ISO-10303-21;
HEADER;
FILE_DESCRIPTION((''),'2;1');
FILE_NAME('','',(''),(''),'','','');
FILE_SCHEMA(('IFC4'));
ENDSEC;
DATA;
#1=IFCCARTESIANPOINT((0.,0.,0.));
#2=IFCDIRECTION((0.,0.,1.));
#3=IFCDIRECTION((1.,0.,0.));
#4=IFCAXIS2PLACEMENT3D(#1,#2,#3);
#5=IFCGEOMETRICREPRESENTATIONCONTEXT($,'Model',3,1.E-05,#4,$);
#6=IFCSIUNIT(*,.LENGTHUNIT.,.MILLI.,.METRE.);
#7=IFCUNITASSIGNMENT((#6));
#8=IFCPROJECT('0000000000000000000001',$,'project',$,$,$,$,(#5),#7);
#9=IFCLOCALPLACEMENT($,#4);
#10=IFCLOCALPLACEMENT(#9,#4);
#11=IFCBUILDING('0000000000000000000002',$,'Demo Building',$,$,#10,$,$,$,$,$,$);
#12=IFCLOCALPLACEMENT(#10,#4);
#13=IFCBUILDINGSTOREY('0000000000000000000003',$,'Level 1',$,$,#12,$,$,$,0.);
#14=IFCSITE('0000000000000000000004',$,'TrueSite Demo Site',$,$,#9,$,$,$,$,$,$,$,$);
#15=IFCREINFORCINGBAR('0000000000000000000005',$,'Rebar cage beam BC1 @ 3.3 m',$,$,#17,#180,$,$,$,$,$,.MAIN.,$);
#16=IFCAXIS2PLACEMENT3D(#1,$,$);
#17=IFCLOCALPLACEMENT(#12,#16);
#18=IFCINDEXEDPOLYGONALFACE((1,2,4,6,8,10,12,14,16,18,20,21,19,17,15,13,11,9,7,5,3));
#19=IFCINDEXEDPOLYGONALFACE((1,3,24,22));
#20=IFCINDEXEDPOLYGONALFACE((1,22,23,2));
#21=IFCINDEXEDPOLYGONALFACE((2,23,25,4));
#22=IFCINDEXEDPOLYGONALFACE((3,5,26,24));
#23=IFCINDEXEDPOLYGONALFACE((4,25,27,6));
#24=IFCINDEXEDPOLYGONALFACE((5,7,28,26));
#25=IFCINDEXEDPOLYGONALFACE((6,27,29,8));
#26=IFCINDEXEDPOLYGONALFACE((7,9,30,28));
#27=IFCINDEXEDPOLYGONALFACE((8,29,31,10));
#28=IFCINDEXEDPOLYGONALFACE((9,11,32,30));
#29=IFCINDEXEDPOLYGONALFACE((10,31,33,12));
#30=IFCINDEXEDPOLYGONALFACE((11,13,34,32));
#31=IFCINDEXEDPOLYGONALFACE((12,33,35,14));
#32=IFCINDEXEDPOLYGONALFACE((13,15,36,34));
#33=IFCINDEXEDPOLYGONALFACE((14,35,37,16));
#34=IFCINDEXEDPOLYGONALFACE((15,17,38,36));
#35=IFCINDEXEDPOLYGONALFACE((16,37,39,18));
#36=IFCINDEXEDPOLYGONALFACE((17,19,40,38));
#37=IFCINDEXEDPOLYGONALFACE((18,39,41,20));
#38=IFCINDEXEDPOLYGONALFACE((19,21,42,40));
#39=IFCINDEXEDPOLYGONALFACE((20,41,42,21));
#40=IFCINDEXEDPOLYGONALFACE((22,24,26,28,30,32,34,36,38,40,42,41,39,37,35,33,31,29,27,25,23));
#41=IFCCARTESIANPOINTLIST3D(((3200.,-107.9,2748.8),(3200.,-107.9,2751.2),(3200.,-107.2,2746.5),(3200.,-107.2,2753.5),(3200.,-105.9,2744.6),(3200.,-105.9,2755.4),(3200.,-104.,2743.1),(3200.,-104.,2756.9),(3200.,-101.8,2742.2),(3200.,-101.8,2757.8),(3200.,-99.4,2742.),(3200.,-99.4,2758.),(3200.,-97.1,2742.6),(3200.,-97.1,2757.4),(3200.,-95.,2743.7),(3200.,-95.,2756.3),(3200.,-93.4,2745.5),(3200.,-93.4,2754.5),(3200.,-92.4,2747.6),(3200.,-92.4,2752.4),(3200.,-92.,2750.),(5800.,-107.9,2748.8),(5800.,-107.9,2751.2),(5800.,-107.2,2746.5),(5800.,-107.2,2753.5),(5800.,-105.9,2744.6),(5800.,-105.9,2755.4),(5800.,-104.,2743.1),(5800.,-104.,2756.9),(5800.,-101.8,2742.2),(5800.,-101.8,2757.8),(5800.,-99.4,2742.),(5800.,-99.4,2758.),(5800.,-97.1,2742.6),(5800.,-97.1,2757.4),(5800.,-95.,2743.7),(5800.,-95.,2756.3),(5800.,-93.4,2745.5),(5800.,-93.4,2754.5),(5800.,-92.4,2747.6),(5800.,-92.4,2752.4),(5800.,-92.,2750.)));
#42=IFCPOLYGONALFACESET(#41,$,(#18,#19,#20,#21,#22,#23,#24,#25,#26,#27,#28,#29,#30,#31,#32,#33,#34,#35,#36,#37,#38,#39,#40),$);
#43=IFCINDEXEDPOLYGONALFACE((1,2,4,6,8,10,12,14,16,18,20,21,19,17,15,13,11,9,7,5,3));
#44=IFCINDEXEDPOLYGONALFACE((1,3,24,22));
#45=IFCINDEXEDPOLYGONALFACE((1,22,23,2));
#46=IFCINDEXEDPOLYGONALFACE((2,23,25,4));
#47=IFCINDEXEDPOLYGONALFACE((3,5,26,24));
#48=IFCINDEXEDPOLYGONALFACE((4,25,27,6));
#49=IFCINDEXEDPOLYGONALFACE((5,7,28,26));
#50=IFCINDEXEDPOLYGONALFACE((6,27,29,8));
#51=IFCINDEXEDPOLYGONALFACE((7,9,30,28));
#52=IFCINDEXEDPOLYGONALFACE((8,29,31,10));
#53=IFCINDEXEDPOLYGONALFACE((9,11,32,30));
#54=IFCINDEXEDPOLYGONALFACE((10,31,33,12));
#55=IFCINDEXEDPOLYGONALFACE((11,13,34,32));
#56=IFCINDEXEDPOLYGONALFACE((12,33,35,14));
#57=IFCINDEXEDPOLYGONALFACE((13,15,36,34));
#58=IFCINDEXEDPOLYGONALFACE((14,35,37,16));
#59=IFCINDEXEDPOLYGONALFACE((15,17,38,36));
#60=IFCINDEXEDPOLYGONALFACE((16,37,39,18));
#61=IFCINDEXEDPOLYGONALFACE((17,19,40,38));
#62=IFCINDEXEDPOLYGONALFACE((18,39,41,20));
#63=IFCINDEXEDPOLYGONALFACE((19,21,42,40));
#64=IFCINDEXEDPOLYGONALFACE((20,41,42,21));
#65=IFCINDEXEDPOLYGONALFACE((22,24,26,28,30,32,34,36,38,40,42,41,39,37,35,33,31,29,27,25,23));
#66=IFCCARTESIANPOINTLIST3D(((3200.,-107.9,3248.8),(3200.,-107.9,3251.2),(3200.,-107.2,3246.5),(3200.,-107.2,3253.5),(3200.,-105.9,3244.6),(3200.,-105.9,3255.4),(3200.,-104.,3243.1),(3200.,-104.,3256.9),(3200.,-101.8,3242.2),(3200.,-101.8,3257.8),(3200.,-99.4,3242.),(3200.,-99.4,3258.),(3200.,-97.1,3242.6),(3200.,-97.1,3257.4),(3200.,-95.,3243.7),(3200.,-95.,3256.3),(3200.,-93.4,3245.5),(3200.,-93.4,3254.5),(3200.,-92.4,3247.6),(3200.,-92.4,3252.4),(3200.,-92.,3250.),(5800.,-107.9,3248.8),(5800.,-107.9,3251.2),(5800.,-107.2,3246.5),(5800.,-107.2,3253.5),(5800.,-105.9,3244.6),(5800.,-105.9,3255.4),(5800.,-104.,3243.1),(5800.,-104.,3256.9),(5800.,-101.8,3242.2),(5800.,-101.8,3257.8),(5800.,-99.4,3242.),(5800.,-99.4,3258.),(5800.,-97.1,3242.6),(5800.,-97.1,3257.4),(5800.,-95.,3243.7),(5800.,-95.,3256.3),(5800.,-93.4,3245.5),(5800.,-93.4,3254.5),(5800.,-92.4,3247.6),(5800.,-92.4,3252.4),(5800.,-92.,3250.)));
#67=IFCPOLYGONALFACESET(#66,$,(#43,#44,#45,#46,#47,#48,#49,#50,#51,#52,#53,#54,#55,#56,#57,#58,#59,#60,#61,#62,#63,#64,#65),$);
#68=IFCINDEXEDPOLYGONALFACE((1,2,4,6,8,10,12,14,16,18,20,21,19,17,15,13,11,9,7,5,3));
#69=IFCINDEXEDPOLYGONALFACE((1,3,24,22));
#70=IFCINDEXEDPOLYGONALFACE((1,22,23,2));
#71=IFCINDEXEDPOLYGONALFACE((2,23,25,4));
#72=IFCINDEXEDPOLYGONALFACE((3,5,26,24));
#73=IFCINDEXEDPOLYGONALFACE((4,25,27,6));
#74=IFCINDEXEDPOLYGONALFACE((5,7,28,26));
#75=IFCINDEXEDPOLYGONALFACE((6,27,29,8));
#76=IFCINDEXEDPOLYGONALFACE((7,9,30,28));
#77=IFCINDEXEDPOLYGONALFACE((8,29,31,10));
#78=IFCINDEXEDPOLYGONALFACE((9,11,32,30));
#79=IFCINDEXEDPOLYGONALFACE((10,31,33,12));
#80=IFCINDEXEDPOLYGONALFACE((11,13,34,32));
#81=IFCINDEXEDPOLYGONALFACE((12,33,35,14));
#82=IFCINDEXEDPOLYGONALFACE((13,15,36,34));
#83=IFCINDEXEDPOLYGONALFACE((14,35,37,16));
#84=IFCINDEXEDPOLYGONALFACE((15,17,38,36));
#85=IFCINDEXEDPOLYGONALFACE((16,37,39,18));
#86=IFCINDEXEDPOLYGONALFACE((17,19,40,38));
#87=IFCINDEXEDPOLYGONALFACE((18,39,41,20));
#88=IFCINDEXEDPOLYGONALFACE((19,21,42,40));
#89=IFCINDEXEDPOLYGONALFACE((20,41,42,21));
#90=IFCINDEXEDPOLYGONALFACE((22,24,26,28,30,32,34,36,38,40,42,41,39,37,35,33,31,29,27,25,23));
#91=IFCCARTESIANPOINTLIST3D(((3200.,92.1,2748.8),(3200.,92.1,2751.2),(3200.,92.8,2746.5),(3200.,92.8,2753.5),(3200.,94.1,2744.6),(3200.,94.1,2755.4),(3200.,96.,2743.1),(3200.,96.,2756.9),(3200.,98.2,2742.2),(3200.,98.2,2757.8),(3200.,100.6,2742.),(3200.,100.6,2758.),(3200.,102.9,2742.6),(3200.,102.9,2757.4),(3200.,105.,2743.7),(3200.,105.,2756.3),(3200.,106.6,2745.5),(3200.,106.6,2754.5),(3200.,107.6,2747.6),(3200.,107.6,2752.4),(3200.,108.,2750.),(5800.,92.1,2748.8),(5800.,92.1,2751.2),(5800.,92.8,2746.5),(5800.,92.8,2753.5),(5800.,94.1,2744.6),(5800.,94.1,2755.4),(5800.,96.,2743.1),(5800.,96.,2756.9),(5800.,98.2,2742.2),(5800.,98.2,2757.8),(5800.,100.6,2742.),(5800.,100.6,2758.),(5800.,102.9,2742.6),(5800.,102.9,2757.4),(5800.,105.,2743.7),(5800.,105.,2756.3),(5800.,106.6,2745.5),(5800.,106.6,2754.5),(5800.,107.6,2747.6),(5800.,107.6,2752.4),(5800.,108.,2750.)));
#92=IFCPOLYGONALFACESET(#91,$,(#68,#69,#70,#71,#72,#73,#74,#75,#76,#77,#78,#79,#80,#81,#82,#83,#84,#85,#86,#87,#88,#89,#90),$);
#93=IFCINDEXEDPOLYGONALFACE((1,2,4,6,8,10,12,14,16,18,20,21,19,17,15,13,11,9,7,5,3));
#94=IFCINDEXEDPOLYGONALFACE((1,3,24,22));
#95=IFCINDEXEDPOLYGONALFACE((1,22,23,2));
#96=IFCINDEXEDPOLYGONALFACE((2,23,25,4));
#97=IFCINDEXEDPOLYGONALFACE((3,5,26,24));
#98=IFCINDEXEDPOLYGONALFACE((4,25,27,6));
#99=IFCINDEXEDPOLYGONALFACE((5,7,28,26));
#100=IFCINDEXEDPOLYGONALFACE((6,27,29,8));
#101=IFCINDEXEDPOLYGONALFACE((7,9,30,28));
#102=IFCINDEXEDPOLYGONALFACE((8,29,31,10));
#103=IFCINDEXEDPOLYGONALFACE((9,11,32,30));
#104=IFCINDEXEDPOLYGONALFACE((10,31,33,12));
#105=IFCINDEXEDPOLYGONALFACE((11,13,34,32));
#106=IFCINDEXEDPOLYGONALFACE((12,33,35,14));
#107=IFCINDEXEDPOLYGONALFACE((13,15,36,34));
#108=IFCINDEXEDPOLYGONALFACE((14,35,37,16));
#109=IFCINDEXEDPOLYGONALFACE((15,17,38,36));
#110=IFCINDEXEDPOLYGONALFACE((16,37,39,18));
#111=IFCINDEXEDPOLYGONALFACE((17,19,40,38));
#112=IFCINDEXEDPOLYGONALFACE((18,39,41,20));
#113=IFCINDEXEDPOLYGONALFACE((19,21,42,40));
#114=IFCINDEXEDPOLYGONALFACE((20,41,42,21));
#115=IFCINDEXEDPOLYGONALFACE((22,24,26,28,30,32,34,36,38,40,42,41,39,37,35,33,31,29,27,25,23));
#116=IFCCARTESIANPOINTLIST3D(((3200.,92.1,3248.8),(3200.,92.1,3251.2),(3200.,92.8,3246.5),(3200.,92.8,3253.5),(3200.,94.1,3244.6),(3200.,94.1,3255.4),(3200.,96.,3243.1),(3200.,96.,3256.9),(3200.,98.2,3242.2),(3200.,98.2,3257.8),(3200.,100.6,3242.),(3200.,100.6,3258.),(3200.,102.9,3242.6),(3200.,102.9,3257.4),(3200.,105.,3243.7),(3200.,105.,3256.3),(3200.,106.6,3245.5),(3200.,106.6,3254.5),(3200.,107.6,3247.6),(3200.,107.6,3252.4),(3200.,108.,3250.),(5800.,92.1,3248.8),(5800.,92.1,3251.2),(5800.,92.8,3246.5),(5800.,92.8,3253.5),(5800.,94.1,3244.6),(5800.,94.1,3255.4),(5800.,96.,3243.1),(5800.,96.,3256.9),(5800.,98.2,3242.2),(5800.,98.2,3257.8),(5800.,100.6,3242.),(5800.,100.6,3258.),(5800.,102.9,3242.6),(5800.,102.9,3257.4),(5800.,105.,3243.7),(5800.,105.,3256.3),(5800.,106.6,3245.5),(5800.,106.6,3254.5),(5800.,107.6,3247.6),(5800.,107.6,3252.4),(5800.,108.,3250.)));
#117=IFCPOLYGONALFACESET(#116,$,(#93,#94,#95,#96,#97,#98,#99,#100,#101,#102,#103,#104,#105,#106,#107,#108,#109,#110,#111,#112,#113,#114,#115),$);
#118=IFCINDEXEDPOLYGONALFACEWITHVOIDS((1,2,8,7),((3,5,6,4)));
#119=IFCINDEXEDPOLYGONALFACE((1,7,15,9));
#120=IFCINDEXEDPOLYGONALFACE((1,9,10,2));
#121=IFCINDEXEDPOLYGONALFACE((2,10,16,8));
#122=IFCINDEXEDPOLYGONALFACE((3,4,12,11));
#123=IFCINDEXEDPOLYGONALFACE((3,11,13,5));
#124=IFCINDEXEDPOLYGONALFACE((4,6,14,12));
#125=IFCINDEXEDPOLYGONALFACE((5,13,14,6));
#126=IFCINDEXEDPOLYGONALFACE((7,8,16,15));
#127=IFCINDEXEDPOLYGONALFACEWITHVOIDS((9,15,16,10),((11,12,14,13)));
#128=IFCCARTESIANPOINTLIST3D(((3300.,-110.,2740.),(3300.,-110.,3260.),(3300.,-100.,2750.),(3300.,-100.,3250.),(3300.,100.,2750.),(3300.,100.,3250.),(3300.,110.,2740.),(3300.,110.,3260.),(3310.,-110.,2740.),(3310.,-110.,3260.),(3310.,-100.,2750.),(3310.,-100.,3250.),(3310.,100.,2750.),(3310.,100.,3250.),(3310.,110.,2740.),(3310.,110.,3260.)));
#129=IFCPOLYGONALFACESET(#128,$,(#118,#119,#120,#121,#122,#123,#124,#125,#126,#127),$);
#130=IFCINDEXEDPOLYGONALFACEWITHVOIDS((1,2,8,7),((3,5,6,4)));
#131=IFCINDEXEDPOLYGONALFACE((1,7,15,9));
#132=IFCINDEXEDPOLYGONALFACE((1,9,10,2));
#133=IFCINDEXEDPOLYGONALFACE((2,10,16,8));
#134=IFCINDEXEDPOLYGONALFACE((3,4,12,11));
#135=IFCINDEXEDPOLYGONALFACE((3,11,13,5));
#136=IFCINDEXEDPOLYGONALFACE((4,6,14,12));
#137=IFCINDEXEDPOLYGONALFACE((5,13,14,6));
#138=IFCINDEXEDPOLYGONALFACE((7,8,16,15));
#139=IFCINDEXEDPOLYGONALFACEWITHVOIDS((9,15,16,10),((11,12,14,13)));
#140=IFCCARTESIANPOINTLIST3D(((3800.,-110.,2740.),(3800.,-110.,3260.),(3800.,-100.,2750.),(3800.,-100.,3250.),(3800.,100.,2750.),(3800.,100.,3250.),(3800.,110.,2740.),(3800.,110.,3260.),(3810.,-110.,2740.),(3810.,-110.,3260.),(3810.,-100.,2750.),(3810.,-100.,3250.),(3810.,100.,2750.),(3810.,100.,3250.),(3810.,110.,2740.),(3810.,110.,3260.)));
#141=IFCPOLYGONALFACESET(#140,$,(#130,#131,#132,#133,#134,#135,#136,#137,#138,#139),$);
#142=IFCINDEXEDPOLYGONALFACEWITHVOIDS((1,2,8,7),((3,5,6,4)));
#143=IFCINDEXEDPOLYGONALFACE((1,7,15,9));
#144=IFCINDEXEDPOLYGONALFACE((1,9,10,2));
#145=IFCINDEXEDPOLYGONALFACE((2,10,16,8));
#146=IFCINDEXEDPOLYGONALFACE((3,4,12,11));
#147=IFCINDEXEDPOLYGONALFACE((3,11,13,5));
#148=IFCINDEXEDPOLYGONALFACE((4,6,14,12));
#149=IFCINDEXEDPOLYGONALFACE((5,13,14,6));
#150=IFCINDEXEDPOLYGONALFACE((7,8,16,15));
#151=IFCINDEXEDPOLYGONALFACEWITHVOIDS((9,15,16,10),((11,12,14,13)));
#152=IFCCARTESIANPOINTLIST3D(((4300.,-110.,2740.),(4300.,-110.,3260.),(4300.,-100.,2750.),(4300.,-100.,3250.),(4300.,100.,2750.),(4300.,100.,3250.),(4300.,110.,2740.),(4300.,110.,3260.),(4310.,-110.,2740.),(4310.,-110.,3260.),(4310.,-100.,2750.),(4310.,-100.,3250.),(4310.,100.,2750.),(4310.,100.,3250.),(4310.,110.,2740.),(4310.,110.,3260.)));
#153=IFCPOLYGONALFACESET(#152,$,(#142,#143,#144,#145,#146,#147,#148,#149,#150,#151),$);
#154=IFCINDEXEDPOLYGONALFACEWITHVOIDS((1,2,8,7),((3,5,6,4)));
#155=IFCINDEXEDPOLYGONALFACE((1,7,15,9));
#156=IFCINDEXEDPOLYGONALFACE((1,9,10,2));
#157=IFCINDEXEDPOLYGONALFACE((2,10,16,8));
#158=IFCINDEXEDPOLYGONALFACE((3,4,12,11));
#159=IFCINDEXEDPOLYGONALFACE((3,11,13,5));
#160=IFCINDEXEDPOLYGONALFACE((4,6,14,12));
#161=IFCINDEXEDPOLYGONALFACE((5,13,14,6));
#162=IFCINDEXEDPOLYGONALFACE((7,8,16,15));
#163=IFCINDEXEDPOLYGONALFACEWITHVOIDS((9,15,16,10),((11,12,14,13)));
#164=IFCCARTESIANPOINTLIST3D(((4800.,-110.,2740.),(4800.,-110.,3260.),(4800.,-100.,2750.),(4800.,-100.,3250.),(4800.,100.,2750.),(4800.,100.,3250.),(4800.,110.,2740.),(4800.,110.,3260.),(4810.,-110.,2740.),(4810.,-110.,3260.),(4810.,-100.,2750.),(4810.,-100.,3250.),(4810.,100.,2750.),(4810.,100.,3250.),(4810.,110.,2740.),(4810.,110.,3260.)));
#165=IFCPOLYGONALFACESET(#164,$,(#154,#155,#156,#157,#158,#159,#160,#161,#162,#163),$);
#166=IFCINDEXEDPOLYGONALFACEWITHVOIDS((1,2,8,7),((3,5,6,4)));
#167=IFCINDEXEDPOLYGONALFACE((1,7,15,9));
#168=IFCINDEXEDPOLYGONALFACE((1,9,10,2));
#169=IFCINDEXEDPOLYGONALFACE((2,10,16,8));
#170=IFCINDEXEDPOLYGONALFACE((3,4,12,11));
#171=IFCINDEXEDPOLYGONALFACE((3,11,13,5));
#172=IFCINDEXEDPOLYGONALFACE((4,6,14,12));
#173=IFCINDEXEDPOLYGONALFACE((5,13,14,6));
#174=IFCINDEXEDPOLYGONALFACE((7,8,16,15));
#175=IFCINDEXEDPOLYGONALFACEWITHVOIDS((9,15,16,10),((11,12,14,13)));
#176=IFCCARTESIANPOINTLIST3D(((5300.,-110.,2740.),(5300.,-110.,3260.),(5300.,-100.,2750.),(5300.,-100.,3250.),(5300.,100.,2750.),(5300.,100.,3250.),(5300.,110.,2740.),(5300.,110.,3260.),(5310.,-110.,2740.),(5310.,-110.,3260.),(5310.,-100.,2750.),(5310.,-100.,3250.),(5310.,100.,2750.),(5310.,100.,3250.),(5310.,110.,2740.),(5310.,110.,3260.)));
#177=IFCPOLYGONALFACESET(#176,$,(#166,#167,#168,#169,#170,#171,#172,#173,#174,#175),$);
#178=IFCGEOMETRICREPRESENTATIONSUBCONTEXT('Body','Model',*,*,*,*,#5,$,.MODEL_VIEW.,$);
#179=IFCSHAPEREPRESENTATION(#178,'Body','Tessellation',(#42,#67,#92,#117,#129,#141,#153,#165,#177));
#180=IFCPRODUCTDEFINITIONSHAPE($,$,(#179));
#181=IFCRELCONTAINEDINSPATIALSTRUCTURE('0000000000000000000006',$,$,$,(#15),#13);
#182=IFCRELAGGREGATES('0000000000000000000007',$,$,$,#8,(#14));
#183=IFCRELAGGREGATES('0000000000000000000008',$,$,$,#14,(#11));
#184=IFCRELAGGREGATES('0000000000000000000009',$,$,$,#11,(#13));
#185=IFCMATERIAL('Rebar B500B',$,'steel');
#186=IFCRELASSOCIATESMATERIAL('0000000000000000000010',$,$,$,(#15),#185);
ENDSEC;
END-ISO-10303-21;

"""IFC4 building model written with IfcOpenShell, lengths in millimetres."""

from ifc_helpers import new_model, si_unit, frame, origin_with_axes, place, context, subcontext, project, spatial, hollow_rectangle, circle, extrude, material, element, save


model = new_model("IFC4")

# Units and contexts
model_context = context("Model", 3, precision=1e-05, world=origin_with_axes())
body_context = subcontext(model_context, "Body", "Model", "MODEL_VIEW")
ifc_project = project(units=[si_unit("LENGTHUNIT", "METRE", prefix="MILLI")], contexts=[model_context])

# Site, building, storey
site_placement = place(None, origin_with_axes())
site = spatial("IfcSite", under=ifc_project, at=site_placement, Name="TrueSite Demo Site")
building_placement = place(site_placement, origin_with_axes())
building = spatial("IfcBuilding", under=site, at=building_placement, Name="Demo Building")
storey_placement = place(building_placement, origin_with_axes())
storey = spatial("IfcBuildingStorey", under=building, at=storey_placement, Name="Level 1", Elevation=0.0)

# Reinforcing bar
ifc_material_1 = material(Name="Rebar B500B", Category="steel")
for number, where, z_axis, x_axis, name in (
    (1, (3200.0, 0.0, 3000.0), (1.0, 0.0, 0.0), (0.0, 1.0, 0.0), "Rebar cage beam BC1 @ 3.3 m"),
):
    element("IfcReinforcingBar", number, at=place(storey_placement, frame(where, z_axis=z_axis, x_axis=x_axis)), inside=storey, material=ifc_material_1, Name=name, PredefinedType="MAIN", context=body_context, shape_type="SweptSolid", body=[
        extrude(circle(Radius=8.0), frame((-100.0, -250.0, 0.0)), (0.0, 0.0, 1.0), 2600.0),
        extrude(circle(Radius=8.0), frame((-100.0, 250.0, 0.0)), (0.0, 0.0, 1.0), 2600.0),
        extrude(circle(Radius=8.0), frame((100.0, -250.0, 0.0)), (0.0, 0.0, 1.0), 2600.0),
        extrude(circle(Radius=8.0), frame((100.0, 250.0, 0.0)), (0.0, 0.0, 1.0), 2600.0),
        extrude(hollow_rectangle(XDim=220.0, YDim=520.0, WallThickness=10.0), frame((0.0, 0.0, 100.0)), (0.0, 0.0, 1.0), 10.0),
        extrude(hollow_rectangle(XDim=220.0, YDim=520.0, WallThickness=10.0), frame((0.0, 0.0, 600.0)), (0.0, 0.0, 1.0), 10.0),
        extrude(hollow_rectangle(XDim=220.0, YDim=520.0, WallThickness=10.0), frame((0.0, 0.0, 1100.0)), (0.0, 0.0, 1.0), 10.0),
        extrude(hollow_rectangle(XDim=220.0, YDim=520.0, WallThickness=10.0), frame((0.0, 0.0, 1600.0)), (0.0, 0.0, 1.0), 10.0),
        extrude(hollow_rectangle(XDim=220.0, YDim=520.0, WallThickness=10.0), frame((0.0, 0.0, 2100.0)), (0.0, 0.0, 1.0), 10.0),
    ])

save(model, "model.ifc")
